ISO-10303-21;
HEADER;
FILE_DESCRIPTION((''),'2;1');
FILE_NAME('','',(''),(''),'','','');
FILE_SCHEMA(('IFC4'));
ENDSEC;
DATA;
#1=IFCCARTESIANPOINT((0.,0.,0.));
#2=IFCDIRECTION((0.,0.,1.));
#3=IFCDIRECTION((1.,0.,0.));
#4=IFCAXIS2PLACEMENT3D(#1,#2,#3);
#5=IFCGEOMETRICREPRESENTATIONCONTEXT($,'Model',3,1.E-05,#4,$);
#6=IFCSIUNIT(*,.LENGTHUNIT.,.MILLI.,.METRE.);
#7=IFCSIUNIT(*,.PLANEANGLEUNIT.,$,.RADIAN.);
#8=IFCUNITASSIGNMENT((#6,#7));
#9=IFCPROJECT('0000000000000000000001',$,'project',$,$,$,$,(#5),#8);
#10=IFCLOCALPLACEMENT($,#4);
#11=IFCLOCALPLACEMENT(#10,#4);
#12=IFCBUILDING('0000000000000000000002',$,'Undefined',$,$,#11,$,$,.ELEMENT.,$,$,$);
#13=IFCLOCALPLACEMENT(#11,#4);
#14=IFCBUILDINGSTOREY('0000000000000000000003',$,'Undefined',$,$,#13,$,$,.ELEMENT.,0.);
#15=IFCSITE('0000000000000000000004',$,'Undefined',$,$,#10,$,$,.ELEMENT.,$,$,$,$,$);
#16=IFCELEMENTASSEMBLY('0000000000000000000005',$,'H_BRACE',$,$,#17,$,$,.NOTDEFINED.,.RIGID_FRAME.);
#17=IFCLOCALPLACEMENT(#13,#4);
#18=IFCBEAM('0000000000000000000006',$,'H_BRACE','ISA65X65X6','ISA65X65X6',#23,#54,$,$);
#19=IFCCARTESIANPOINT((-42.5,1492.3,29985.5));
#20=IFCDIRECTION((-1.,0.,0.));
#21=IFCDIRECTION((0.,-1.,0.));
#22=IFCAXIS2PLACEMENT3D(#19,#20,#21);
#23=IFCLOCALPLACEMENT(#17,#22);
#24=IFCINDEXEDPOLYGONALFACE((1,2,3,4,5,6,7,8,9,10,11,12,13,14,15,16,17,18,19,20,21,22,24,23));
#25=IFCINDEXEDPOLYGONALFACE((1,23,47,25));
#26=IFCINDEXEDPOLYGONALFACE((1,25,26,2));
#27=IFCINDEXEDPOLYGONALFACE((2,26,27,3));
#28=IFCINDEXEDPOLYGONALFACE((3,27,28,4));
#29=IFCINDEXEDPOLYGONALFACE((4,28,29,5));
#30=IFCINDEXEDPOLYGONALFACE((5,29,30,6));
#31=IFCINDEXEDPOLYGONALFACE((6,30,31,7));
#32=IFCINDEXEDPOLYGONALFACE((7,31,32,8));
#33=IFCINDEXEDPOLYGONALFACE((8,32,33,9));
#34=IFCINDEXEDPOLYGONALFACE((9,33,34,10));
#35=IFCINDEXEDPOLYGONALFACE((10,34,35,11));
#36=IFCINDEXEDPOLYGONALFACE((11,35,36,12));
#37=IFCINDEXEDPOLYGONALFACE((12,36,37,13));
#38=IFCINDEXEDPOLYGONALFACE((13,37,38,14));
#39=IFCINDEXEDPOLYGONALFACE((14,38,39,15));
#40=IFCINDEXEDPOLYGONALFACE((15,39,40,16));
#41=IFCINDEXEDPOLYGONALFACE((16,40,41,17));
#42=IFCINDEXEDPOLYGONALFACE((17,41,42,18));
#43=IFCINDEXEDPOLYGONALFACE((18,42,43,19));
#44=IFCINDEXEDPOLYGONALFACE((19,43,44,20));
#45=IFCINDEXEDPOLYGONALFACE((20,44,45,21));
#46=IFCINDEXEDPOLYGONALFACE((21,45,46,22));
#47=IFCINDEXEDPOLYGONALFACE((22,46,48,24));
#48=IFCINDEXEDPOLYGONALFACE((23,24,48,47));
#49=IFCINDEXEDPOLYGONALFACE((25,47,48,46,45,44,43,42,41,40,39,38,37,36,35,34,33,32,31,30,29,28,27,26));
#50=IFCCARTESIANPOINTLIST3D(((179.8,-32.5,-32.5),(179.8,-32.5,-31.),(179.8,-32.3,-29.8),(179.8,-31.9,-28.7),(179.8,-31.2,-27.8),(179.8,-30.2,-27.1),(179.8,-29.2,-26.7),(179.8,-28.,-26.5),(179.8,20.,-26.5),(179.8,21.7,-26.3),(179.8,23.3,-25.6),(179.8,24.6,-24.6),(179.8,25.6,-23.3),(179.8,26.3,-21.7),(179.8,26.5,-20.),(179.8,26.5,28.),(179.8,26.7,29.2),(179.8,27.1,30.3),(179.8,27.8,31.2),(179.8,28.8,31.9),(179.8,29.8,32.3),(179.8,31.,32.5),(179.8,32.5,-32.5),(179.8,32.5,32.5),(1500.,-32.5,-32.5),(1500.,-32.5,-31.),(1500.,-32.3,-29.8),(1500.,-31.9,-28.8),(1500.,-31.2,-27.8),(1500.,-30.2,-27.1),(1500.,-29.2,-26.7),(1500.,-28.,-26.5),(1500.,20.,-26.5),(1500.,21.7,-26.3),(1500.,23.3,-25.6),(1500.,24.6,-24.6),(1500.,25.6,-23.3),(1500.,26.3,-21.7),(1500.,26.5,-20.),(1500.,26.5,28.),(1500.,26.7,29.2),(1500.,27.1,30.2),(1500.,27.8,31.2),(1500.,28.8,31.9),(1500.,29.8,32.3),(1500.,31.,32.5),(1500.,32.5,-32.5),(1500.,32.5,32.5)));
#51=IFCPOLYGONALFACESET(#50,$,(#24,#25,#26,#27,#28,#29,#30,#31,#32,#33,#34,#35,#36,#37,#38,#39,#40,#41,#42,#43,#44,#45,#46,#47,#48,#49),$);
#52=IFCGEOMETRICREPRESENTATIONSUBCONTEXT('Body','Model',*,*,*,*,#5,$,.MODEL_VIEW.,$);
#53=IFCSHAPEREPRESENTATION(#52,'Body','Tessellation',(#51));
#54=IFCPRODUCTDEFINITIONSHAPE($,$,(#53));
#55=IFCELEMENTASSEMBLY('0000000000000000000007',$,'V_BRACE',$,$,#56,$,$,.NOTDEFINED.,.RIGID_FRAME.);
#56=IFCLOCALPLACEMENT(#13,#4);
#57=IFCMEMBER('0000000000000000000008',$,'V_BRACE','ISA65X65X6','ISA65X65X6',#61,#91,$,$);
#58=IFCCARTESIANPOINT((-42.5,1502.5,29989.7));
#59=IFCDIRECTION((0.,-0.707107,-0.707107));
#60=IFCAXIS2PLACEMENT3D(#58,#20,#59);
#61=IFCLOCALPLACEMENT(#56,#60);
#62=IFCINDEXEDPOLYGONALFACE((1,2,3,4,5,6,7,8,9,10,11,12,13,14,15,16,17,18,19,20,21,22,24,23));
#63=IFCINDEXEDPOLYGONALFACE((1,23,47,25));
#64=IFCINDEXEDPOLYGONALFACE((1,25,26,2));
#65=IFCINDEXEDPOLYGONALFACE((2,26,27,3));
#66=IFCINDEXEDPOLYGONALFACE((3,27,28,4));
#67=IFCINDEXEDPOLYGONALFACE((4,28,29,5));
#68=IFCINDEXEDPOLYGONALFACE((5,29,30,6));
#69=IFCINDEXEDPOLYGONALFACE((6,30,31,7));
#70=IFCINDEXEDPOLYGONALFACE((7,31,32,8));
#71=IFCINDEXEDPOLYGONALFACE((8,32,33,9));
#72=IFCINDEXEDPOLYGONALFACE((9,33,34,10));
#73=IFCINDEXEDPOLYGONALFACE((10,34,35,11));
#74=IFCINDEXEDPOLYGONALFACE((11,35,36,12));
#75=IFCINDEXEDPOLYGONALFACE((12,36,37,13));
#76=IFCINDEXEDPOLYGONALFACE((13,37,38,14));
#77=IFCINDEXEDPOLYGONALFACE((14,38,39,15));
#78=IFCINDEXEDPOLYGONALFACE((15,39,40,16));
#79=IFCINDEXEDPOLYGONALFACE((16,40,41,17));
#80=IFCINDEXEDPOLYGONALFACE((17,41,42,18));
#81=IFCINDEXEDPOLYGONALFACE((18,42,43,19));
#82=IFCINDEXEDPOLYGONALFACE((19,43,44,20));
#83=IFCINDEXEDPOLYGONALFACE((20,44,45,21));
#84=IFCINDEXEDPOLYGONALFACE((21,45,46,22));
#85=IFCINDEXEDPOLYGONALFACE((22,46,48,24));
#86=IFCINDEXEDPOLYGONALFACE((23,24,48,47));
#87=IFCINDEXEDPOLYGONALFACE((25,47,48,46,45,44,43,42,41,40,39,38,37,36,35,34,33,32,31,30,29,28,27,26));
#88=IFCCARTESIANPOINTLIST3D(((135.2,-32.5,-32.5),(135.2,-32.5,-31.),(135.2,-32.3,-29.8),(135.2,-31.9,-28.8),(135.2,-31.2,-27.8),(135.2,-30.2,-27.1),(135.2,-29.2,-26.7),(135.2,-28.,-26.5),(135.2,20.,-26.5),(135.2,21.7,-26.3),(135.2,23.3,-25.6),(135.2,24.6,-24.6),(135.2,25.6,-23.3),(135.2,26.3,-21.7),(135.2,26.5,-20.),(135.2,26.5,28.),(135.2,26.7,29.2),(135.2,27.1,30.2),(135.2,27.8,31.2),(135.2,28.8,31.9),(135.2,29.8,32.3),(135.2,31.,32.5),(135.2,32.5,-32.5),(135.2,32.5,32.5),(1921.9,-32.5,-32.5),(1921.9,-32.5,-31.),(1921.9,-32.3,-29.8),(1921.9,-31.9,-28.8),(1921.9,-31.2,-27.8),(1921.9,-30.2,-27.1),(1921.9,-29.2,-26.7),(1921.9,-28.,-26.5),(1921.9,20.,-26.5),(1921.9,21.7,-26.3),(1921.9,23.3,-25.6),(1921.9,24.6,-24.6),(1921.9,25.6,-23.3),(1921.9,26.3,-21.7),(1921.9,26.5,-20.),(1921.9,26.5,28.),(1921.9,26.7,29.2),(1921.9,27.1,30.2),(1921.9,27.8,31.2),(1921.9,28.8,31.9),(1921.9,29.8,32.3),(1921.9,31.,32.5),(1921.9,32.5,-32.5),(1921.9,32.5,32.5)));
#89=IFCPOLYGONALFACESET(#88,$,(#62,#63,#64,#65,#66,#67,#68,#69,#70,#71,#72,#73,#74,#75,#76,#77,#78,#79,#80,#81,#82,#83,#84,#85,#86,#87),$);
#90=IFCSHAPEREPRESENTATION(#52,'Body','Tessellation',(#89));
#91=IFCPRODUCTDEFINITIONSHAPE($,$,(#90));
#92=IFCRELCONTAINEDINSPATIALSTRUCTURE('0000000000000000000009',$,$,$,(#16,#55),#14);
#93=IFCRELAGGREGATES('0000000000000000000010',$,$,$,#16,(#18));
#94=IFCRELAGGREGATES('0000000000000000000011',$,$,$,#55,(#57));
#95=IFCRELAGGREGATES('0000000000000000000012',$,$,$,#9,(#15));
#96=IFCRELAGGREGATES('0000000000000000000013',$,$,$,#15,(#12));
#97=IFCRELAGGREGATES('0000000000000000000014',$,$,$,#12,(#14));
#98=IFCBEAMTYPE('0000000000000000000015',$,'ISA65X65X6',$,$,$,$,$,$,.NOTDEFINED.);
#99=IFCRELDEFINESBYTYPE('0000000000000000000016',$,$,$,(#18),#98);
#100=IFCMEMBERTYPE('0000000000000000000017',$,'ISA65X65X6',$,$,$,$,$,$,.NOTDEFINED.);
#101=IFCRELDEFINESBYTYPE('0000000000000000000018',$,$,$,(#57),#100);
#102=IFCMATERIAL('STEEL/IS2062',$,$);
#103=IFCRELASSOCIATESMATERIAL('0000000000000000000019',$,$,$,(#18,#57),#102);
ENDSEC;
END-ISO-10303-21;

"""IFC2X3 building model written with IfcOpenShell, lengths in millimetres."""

from ifc_helpers import new_model, si_unit, frame, origin_with_axes, origin_2d_with_axis, place, context, subcontext, project, spatial, l_section, extrude, clip, halfspace, material, type_object, element, aggregate, save


model = new_model("IFC2X3")

# Units and contexts
model_context = context("Model", 3, precision=1e-05, world=origin_with_axes())
body_context = subcontext(model_context, "Body", "Model", "MODEL_VIEW")
ifc_project = project(units=[si_unit("LENGTHUNIT", "METRE", prefix="MILLI"), si_unit("PLANEANGLEUNIT", "RADIAN")], contexts=[model_context])

# Site, building, storey
site_placement = place(None, origin_with_axes())
site = spatial("IfcSite", under=ifc_project, at=site_placement, Name="Undefined", CompositionType="ELEMENT")
building_placement = place(site_placement, origin_with_axes())
building = spatial("IfcBuilding", under=site, at=building_placement, Name="Undefined", CompositionType="ELEMENT")
storey_placement = place(building_placement, origin_with_axes())
storey = spatial("IfcBuildingStorey", under=building, at=storey_placement, Name="Undefined", CompositionType="ELEMENT", Elevation=0.0)

# Shared definitions
ifc_material = material(Name="STEEL/IS2062")

# Element assembly, beam
beam_type_1 = type_object("IfcBeamType", Name="ISA65X65X6", PredefinedType="NOTDEFINED")
assembly_1_placement = place(storey_placement, origin_with_axes())
assembly_1 = element("IfcElementAssembly", 1, at=assembly_1_placement, inside=storey, Name="H_BRACE", AssemblyPlace="NOTDEFINED", PredefinedType="RIGID_FRAME")
beam_1_placement = place(assembly_1_placement, frame((-42.5, 1492.3, 29985.5), z_axis=(-1.0, 0.0, 0.0), x_axis=(0.0, -1.0, 0.0)))
beam_1 = element("IfcBeam", 2, at=beam_1_placement, type_object=beam_type_1, material=ifc_material, Name="H_BRACE", Description="ISA65X65X6", ObjectType="ISA65X65X6", context=body_context, shape_type="Clipping", body=[
    clip(extrude(l_section(Depth=65.0, Width=65.0, Thickness=6.0, FilletRadius=6.5, EdgeRadius=4.5, at=origin_2d_with_axis()), frame((1500.0, 0.0, 0.0), z_axis=(-1.0, 0.0, 0.0), x_axis=(0.0, -1.0, 0.0)), (0.0, 0.0, 1.0), 1500.0), halfspace(frame((179.8, 0.0, -32.5), z_axis=(1.0, 0.0, 0.0), x_axis=(0.0, 1.0, 0.0)), True)),
])
aggregate(assembly_1, [beam_1])

# Element assembly, member
assembly_2_placement = place(storey_placement, origin_with_axes())
assembly_2 = element("IfcElementAssembly", 3, at=assembly_2_placement, inside=storey, Name="V_BRACE", AssemblyPlace="NOTDEFINED", PredefinedType="RIGID_FRAME")
member_type = type_object("IfcMemberType", Name="ISA65X65X6", PredefinedType="NOTDEFINED")
member_placement = place(assembly_2_placement, frame((-42.5, 1502.5, 29989.7), z_axis=(-1.0, 0.0, 0.0), x_axis=(0.0, -0.707107, -0.707107)))
member = element("IfcMember", 4, at=member_placement, type_object=member_type, material=ifc_material, Name="V_BRACE", Description="ISA65X65X6", ObjectType="ISA65X65X6", context=body_context, shape_type="Clipping", body=[
    clip(clip(extrude(l_section(Depth=65.0, Width=65.0, Thickness=6.0, FilletRadius=6.5, EdgeRadius=4.5, at=origin_2d_with_axis()), frame((2121.3, 0.0, 0.0), z_axis=(-1.0, 0.0, 0.0), x_axis=(0.0, -1.0, 0.0)), (0.0, 0.0, 1.0), 2121.3), halfspace(frame((1921.9, 0.0, -32.5), z_axis=(-1.0, 0.0, 0.0), x_axis=(0.0, -1.0, 0.0)), True)), halfspace(frame((135.2, 0.0, -32.5), z_axis=(1.0, 0.0, 0.0), x_axis=(0.0, 1.0, 0.0)), True)),
])
aggregate(assembly_2, [member])

save(model, "model.ifc")
